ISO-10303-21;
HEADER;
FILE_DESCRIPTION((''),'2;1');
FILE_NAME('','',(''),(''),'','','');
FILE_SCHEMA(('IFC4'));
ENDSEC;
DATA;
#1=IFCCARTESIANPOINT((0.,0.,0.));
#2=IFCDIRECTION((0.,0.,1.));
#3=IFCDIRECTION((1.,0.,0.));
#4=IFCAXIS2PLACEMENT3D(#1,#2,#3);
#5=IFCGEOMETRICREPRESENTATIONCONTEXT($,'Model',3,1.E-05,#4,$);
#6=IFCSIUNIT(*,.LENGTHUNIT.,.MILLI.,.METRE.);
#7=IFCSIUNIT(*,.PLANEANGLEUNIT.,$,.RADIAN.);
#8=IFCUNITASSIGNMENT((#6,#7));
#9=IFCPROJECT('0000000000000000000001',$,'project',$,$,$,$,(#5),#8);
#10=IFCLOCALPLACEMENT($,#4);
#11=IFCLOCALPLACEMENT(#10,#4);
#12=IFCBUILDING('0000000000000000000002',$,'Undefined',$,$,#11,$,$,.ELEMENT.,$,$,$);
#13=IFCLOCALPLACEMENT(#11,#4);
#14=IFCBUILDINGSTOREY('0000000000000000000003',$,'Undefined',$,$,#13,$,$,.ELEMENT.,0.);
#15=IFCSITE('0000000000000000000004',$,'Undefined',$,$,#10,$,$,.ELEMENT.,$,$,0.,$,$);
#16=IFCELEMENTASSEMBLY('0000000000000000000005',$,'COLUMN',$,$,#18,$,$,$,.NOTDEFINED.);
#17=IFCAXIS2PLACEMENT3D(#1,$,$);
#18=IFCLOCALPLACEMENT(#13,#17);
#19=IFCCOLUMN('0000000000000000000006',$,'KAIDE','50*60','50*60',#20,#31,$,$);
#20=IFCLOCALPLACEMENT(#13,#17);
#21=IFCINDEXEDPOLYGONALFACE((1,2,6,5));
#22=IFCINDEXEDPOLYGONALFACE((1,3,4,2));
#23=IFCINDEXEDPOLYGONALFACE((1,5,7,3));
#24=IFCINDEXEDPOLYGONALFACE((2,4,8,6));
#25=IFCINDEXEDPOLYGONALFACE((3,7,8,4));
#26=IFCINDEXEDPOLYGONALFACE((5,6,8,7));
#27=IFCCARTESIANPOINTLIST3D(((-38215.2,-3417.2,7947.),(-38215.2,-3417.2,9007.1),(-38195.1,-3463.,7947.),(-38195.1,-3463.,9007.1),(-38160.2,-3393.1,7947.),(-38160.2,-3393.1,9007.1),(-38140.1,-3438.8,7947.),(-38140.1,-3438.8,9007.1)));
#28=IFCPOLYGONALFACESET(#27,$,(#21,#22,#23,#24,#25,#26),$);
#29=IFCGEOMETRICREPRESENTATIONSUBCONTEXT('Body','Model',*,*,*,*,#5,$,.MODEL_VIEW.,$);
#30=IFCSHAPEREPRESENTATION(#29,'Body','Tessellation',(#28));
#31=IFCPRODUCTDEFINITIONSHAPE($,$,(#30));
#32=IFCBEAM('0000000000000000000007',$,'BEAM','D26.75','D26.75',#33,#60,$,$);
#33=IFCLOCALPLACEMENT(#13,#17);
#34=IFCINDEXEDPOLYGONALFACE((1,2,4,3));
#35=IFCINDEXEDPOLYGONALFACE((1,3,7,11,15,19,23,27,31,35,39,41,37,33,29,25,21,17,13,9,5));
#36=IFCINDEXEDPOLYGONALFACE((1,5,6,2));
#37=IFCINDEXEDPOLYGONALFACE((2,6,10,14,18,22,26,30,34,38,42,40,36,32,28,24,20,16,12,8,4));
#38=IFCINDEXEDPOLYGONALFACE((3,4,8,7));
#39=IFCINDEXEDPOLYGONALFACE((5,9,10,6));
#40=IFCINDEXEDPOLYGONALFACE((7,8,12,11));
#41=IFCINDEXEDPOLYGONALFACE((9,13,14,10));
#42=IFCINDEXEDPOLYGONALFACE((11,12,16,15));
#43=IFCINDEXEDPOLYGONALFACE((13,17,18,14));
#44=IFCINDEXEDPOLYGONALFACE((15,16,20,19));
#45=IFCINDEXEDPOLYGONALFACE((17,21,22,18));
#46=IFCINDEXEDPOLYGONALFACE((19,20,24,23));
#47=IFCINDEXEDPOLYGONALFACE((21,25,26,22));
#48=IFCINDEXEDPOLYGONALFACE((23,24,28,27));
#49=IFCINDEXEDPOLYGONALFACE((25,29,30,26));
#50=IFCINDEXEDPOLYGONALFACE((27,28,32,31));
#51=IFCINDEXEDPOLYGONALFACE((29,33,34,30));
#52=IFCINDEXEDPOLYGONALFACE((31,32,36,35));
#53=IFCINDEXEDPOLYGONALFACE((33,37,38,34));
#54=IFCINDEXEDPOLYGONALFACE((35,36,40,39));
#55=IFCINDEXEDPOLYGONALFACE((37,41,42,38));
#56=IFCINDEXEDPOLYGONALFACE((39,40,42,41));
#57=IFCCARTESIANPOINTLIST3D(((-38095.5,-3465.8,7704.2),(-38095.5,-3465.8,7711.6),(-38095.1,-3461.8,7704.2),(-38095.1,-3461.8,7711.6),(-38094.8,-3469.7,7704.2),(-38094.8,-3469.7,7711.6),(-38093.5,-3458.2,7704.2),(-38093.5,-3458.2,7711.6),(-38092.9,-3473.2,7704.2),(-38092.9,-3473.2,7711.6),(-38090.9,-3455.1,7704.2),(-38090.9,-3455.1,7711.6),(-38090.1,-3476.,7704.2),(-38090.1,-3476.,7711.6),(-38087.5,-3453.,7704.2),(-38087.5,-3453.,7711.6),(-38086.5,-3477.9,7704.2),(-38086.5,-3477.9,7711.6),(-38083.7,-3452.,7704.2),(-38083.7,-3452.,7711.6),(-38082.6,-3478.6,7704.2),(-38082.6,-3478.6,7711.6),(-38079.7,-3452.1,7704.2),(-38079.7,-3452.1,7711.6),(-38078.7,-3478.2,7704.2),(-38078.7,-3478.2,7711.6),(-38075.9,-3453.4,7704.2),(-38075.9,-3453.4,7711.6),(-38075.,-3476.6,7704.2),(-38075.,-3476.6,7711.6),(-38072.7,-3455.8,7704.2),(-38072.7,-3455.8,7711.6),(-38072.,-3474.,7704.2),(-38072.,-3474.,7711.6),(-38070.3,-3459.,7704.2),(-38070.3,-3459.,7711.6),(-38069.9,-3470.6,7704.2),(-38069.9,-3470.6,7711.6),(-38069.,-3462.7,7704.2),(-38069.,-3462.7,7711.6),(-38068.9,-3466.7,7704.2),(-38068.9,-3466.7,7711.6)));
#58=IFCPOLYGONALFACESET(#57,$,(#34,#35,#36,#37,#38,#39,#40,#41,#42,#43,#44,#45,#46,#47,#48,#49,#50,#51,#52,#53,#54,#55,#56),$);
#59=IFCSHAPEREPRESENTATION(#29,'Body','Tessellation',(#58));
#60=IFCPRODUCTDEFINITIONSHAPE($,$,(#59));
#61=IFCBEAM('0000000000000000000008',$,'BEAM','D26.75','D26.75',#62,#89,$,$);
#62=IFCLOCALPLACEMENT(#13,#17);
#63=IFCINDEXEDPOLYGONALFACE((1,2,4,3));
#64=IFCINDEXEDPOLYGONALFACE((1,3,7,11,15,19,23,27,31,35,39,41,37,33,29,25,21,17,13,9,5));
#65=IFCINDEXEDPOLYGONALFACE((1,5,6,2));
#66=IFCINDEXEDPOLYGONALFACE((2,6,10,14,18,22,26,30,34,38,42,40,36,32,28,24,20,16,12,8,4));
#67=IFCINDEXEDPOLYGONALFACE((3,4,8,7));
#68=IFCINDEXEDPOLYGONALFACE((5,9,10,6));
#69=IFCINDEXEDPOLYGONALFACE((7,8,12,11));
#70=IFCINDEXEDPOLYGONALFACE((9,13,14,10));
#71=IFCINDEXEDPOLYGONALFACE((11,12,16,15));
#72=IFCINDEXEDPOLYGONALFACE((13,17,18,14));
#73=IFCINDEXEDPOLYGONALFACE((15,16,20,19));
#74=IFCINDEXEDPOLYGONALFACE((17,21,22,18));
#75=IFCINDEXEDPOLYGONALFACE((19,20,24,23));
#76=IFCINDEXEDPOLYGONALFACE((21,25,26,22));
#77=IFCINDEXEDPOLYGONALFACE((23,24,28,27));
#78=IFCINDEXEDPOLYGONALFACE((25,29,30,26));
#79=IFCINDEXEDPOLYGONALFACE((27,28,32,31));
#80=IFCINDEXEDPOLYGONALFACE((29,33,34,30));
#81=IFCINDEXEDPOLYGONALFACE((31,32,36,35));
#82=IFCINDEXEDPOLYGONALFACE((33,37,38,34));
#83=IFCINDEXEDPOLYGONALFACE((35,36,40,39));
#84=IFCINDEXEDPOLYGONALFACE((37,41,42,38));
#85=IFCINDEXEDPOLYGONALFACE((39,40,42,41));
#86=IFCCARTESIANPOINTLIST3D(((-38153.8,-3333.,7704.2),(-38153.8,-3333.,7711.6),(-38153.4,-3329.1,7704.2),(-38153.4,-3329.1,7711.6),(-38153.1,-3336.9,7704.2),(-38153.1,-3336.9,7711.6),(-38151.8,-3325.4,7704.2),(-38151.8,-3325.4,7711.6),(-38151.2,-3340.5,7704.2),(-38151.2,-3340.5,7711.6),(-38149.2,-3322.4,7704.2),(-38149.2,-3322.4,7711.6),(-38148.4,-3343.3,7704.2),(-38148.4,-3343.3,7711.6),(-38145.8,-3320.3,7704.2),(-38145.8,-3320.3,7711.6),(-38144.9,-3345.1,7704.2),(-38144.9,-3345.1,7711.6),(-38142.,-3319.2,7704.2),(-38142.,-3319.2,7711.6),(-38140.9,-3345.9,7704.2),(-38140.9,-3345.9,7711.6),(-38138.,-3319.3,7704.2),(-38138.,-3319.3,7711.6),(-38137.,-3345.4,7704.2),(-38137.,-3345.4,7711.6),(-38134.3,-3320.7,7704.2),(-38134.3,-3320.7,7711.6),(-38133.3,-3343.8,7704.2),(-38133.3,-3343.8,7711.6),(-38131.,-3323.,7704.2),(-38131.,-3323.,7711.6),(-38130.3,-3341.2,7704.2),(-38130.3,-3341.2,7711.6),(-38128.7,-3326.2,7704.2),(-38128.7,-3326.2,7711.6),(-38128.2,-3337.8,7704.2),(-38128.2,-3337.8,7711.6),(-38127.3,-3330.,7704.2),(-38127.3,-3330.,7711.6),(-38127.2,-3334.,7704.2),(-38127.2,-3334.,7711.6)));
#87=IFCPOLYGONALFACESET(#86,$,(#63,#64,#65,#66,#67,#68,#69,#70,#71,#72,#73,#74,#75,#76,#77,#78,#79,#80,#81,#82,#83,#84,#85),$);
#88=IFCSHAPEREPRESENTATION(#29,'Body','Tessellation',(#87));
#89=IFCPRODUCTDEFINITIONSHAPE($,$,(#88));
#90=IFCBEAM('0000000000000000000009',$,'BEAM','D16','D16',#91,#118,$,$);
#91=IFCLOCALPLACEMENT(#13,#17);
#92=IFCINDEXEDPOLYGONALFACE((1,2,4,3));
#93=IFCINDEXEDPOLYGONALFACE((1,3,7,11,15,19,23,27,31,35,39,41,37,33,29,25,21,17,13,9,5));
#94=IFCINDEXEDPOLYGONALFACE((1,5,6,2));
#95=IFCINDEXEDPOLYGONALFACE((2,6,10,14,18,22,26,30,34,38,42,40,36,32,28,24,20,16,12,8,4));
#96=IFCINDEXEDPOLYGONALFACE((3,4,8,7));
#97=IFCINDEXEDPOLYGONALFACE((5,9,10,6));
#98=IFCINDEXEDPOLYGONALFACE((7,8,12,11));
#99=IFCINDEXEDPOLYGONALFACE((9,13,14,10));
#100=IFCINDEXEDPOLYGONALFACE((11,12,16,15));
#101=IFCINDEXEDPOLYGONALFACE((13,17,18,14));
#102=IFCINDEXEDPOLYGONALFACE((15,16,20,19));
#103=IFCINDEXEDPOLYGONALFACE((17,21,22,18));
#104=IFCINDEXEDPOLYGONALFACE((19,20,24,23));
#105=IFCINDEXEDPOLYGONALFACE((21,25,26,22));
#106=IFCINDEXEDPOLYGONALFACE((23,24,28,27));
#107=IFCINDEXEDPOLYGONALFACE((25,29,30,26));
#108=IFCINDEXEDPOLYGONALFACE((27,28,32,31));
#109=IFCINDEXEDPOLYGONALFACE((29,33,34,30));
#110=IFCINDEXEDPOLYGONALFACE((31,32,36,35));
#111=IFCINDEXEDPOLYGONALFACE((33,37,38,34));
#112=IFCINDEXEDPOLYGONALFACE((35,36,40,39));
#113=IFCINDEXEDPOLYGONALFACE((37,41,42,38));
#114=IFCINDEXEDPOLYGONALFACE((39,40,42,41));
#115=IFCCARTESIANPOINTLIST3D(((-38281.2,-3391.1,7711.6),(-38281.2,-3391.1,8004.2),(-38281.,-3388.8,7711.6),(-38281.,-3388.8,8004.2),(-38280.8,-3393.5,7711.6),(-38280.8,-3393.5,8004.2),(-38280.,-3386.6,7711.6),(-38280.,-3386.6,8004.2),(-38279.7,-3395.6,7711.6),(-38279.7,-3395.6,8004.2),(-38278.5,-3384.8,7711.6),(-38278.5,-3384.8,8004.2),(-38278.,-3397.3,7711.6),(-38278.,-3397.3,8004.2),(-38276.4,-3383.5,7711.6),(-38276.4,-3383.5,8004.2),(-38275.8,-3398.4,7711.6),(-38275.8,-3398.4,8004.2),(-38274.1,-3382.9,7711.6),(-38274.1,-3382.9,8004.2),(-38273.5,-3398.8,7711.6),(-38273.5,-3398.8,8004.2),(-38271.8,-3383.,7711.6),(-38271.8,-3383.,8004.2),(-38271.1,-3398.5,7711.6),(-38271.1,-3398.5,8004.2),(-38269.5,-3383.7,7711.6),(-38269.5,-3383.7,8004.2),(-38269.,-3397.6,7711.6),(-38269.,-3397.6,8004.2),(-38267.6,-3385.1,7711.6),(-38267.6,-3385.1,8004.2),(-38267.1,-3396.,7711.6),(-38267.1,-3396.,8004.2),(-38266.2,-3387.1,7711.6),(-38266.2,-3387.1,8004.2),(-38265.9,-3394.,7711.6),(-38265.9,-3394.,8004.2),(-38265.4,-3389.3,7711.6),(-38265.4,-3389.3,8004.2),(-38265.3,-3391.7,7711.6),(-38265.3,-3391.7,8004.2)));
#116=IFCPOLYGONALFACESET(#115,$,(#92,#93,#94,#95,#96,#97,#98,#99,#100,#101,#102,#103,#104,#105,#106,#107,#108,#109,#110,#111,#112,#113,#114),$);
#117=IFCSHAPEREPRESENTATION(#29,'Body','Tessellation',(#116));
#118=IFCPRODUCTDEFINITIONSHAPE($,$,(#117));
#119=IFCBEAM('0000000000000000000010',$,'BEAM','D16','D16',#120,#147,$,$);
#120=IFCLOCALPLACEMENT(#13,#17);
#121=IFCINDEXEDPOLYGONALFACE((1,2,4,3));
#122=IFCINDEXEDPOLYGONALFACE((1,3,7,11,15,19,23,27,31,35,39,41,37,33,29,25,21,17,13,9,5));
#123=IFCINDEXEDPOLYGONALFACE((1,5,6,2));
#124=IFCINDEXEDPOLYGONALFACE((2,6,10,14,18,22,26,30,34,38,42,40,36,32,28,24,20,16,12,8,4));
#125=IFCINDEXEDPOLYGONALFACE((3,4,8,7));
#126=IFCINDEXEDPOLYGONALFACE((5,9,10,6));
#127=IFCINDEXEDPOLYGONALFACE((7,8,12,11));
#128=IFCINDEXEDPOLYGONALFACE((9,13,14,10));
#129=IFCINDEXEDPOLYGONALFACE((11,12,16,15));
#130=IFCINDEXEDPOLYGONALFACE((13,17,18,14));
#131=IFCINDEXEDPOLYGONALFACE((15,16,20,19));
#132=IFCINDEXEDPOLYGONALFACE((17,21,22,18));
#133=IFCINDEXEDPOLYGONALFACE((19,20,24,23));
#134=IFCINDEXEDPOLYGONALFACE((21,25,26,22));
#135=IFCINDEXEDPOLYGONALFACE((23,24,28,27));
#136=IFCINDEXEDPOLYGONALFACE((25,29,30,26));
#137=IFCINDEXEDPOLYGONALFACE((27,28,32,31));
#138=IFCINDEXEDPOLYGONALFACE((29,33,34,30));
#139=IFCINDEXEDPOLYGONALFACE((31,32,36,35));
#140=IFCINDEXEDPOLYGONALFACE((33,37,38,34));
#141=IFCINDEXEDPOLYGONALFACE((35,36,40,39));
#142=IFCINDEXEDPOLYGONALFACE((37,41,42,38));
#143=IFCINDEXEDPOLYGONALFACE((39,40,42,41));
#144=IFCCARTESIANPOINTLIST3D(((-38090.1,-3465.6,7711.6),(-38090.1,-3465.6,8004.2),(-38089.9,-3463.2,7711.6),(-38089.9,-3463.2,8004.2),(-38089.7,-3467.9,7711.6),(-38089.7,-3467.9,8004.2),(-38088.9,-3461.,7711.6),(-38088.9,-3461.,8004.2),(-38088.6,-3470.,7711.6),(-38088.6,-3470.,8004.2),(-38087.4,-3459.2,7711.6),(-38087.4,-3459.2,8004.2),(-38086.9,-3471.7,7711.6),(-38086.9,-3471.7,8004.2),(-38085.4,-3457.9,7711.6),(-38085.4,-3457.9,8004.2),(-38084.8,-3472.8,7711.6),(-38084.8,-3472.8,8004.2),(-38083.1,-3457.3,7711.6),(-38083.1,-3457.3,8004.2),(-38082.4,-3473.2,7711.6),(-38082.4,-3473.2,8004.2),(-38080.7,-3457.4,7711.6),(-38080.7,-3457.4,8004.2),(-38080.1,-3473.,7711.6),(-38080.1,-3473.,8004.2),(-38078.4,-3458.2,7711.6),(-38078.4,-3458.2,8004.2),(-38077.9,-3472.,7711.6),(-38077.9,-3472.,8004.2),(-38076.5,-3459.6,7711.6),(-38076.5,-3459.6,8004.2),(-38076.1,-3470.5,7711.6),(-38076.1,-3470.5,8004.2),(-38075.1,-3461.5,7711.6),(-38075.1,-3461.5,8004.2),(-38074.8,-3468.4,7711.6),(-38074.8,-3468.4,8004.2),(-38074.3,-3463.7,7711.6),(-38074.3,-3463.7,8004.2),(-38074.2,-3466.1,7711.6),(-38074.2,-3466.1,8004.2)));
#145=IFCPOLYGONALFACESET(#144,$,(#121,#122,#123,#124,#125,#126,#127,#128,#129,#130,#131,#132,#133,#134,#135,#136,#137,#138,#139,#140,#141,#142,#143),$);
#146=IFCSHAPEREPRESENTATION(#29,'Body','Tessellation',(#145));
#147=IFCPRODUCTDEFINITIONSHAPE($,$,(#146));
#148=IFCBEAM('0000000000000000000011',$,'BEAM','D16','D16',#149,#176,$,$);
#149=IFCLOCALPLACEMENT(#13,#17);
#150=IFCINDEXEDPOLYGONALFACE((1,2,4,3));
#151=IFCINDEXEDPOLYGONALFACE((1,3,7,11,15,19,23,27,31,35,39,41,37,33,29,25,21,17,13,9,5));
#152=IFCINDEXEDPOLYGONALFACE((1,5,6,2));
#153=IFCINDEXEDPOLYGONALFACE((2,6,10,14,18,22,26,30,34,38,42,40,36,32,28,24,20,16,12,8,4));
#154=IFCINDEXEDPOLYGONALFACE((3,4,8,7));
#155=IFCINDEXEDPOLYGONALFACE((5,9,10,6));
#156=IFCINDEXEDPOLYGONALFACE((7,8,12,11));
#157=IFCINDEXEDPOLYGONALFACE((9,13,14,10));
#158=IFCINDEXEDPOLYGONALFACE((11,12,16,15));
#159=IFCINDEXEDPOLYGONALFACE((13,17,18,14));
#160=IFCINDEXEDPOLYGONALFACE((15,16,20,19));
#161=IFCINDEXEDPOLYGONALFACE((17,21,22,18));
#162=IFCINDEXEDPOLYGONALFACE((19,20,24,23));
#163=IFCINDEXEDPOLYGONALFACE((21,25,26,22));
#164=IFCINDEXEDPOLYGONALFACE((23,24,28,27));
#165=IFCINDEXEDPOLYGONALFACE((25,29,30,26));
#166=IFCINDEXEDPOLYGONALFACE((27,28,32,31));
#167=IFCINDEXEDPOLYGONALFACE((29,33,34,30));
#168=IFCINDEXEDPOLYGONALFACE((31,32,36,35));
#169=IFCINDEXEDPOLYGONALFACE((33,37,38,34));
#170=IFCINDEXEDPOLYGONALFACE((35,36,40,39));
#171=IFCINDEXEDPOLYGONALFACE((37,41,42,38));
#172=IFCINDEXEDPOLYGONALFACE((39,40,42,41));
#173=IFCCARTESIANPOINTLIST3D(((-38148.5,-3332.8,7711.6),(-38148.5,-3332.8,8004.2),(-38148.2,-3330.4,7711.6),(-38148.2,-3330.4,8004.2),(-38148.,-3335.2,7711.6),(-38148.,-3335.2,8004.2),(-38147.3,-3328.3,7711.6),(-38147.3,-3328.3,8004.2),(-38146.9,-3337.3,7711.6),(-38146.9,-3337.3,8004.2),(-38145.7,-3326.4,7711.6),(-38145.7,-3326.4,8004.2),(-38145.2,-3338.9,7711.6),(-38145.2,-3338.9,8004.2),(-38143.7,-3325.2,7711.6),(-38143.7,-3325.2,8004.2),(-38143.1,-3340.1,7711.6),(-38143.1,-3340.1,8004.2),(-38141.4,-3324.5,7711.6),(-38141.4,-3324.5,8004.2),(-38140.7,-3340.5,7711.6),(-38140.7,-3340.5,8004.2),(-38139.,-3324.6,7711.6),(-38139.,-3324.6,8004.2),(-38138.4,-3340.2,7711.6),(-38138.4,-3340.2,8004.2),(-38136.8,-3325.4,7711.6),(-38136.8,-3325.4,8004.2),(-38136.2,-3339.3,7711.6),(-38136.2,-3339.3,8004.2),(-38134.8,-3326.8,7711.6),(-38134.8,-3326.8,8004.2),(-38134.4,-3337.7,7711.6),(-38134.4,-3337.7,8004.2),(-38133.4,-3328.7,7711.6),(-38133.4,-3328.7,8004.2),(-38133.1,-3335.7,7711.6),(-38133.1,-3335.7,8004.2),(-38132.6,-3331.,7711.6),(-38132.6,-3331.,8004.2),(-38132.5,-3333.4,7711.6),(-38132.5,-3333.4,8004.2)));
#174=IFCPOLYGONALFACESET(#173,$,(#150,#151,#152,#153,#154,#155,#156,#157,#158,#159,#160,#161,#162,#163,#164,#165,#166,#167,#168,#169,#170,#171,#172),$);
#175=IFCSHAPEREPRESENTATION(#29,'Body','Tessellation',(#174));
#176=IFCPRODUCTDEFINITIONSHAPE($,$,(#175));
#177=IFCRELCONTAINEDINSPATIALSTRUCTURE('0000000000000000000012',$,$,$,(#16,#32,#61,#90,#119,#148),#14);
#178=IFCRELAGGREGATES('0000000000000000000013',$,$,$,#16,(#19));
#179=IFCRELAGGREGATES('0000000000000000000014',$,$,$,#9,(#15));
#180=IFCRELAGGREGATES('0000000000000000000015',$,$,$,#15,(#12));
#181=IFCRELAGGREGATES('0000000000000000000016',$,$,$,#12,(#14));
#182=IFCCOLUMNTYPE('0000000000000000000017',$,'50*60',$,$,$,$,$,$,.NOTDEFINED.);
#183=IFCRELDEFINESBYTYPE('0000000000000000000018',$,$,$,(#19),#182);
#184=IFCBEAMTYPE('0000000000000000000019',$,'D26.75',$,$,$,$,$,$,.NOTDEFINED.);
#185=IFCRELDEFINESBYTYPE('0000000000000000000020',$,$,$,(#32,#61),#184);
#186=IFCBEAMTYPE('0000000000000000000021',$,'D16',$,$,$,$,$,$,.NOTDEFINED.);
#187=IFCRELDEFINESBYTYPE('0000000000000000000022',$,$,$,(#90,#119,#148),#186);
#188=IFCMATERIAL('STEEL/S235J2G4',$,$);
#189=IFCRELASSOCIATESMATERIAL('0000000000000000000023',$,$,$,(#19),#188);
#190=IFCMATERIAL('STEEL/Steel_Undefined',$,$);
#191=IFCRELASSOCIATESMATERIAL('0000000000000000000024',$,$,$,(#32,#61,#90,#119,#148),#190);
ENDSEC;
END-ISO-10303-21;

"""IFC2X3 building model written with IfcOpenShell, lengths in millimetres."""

from ifc_helpers import new_model, si_unit, frame, origin_with_axes, origin_2d_with_axis, place, context, subcontext, project, spatial, rectangle, circle, extrude, material, type_object, element, aggregate, save


model = new_model("IFC2X3")

# Units and contexts
model_context = context("Model", 3, precision=1e-05, world=origin_with_axes())
body_context = subcontext(model_context, "Body", "Model", "MODEL_VIEW")
ifc_project = project(units=[si_unit("LENGTHUNIT", "METRE", prefix="MILLI"), si_unit("PLANEANGLEUNIT", "RADIAN")], contexts=[model_context])

# Site, building, storey
site_placement = place(None, origin_with_axes())
site = spatial("IfcSite", under=ifc_project, at=site_placement, Name="Undefined", CompositionType="ELEMENT", RefElevation=0.0)
building_placement = place(site_placement, origin_with_axes())
building = spatial("IfcBuilding", under=site, at=building_placement, Name="Undefined", CompositionType="ELEMENT")
storey_placement = place(building_placement, origin_with_axes())
storey = spatial("IfcBuildingStorey", under=building, at=storey_placement, Name="Undefined", CompositionType="ELEMENT", Elevation=0.0)

# Element assembly, column
assembly_placement = place(storey_placement, frame((-38177.7, -3428.0, 7947.0), z_axis=(-0.402197, 0.915553, 0.0), x_axis=(0.0, 0.0, 1.0)))
assembly = element("IfcElementAssembly", 1, at=assembly_placement, inside=storey, Name="COLUMN", PredefinedType="NOTDEFINED")
ifc_material_1 = material(Name="STEEL/S235J2G4")
column_type = type_object("IfcColumnType", Name="50*60", PredefinedType="NOTDEFINED")
column_placement = place(storey_placement, frame((-38177.7, -3428.0, 7947.0), z_axis=(0.0, 0.0, 1.0), x_axis=(1.0, 0.0, 0.0)))
column = element("IfcColumn", 2, at=column_placement, type_object=column_type, material=ifc_material_1, Name="KAIDE", Description="50*60", ObjectType="50*60", context=body_context, shape_type="SweptSolid", body=[
    extrude(rectangle(XDim=60.0, YDim=50.0, at=origin_2d_with_axis()), frame((0.0, 0.0, 1060.0), z_axis=(0.0, 0.0, -1.0), x_axis=(-0.915553, -0.402197, 0.0)), (0.0, 0.0, 1.0), 1060.0),
])
aggregate(assembly, [column])

# Shared definitions
ifc_material_2 = material(Name="STEEL/Steel_Undefined")
beam_type_1 = type_object("IfcBeamType", Name="D26.75", PredefinedType="NOTDEFINED")

# Beam
beam_1_placement = place(storey_placement, frame((-38082.2, -3465.3, 7711.6), z_axis=(-0.915553, -0.402197, 0.0), x_axis=(0.0, 0.0, -1.0)))
element("IfcBeam", 3, at=beam_1_placement, inside=storey, type_object=beam_type_1, material=ifc_material_2, Name="BEAM", Description="D26.75", ObjectType="D26.75", context=body_context, shape_type="SweptSolid", body=[
    extrude(circle(Radius=13.4, at=origin_2d_with_axis()), frame((7.4, 0.0, 0.0), z_axis=(-1.0, 0.0, 0.0), x_axis=(0.0, -1.0, 0.0)), (0.0, 0.0, 1.0), 7.4),
])

# Beam
beam_2_placement = place(storey_placement, frame((-38140.5, -3332.5, 7711.6), z_axis=(-0.915553, -0.402197, 0.0), x_axis=(0.0, 0.0, -1.0)))
element("IfcBeam", 4, at=beam_2_placement, inside=storey, type_object=beam_type_1, material=ifc_material_2, Name="BEAM", Description="D26.75", ObjectType="D26.75", context=body_context, shape_type="SweptSolid", body=[
    extrude(circle(Radius=13.4, at=origin_2d_with_axis()), frame((7.4, 0.0, 0.0), z_axis=(-1.0, 0.0, 0.0), x_axis=(0.0, -1.0, 0.0)), (0.0, 0.0, 1.0), 7.4),
])

# Beams
beam_type_2 = type_object("IfcBeamType", Name="D16", PredefinedType="NOTDEFINED")
for number, where, z_axis, x_axis, name in (
    (5, (-38273.2, -3390.8, 8004.2), (-0.915553, -0.402197, 0.0), (0.0, 0.0, -1.0), "BEAM"),
    (6, (-38082.2, -3465.3, 8004.2), (-0.915553, -0.402197, 0.0), (0.0, 0.0, -1.0), "BEAM"),
    (7, (-38140.5, -3332.5, 8004.2), (-0.915553, -0.402197, 0.0), (0.0, 0.0, -1.0), "BEAM"),
):
    element("IfcBeam", number, at=place(storey_placement, frame(where, z_axis=z_axis, x_axis=x_axis)), inside=storey, type_object=beam_type_2, material=ifc_material_2, Name=name, Description="D16", ObjectType="D16", context=body_context, shape_type="SweptSolid", body=[
        extrude(circle(Radius=8.0, at=origin_2d_with_axis()), frame((292.6, 0.0, 0.0), z_axis=(-1.0, 0.0, 0.0), x_axis=(0.0, -1.0, 0.0)), (0.0, 0.0, 1.0), 292.6),
    ])

save(model, "model.ifc")
